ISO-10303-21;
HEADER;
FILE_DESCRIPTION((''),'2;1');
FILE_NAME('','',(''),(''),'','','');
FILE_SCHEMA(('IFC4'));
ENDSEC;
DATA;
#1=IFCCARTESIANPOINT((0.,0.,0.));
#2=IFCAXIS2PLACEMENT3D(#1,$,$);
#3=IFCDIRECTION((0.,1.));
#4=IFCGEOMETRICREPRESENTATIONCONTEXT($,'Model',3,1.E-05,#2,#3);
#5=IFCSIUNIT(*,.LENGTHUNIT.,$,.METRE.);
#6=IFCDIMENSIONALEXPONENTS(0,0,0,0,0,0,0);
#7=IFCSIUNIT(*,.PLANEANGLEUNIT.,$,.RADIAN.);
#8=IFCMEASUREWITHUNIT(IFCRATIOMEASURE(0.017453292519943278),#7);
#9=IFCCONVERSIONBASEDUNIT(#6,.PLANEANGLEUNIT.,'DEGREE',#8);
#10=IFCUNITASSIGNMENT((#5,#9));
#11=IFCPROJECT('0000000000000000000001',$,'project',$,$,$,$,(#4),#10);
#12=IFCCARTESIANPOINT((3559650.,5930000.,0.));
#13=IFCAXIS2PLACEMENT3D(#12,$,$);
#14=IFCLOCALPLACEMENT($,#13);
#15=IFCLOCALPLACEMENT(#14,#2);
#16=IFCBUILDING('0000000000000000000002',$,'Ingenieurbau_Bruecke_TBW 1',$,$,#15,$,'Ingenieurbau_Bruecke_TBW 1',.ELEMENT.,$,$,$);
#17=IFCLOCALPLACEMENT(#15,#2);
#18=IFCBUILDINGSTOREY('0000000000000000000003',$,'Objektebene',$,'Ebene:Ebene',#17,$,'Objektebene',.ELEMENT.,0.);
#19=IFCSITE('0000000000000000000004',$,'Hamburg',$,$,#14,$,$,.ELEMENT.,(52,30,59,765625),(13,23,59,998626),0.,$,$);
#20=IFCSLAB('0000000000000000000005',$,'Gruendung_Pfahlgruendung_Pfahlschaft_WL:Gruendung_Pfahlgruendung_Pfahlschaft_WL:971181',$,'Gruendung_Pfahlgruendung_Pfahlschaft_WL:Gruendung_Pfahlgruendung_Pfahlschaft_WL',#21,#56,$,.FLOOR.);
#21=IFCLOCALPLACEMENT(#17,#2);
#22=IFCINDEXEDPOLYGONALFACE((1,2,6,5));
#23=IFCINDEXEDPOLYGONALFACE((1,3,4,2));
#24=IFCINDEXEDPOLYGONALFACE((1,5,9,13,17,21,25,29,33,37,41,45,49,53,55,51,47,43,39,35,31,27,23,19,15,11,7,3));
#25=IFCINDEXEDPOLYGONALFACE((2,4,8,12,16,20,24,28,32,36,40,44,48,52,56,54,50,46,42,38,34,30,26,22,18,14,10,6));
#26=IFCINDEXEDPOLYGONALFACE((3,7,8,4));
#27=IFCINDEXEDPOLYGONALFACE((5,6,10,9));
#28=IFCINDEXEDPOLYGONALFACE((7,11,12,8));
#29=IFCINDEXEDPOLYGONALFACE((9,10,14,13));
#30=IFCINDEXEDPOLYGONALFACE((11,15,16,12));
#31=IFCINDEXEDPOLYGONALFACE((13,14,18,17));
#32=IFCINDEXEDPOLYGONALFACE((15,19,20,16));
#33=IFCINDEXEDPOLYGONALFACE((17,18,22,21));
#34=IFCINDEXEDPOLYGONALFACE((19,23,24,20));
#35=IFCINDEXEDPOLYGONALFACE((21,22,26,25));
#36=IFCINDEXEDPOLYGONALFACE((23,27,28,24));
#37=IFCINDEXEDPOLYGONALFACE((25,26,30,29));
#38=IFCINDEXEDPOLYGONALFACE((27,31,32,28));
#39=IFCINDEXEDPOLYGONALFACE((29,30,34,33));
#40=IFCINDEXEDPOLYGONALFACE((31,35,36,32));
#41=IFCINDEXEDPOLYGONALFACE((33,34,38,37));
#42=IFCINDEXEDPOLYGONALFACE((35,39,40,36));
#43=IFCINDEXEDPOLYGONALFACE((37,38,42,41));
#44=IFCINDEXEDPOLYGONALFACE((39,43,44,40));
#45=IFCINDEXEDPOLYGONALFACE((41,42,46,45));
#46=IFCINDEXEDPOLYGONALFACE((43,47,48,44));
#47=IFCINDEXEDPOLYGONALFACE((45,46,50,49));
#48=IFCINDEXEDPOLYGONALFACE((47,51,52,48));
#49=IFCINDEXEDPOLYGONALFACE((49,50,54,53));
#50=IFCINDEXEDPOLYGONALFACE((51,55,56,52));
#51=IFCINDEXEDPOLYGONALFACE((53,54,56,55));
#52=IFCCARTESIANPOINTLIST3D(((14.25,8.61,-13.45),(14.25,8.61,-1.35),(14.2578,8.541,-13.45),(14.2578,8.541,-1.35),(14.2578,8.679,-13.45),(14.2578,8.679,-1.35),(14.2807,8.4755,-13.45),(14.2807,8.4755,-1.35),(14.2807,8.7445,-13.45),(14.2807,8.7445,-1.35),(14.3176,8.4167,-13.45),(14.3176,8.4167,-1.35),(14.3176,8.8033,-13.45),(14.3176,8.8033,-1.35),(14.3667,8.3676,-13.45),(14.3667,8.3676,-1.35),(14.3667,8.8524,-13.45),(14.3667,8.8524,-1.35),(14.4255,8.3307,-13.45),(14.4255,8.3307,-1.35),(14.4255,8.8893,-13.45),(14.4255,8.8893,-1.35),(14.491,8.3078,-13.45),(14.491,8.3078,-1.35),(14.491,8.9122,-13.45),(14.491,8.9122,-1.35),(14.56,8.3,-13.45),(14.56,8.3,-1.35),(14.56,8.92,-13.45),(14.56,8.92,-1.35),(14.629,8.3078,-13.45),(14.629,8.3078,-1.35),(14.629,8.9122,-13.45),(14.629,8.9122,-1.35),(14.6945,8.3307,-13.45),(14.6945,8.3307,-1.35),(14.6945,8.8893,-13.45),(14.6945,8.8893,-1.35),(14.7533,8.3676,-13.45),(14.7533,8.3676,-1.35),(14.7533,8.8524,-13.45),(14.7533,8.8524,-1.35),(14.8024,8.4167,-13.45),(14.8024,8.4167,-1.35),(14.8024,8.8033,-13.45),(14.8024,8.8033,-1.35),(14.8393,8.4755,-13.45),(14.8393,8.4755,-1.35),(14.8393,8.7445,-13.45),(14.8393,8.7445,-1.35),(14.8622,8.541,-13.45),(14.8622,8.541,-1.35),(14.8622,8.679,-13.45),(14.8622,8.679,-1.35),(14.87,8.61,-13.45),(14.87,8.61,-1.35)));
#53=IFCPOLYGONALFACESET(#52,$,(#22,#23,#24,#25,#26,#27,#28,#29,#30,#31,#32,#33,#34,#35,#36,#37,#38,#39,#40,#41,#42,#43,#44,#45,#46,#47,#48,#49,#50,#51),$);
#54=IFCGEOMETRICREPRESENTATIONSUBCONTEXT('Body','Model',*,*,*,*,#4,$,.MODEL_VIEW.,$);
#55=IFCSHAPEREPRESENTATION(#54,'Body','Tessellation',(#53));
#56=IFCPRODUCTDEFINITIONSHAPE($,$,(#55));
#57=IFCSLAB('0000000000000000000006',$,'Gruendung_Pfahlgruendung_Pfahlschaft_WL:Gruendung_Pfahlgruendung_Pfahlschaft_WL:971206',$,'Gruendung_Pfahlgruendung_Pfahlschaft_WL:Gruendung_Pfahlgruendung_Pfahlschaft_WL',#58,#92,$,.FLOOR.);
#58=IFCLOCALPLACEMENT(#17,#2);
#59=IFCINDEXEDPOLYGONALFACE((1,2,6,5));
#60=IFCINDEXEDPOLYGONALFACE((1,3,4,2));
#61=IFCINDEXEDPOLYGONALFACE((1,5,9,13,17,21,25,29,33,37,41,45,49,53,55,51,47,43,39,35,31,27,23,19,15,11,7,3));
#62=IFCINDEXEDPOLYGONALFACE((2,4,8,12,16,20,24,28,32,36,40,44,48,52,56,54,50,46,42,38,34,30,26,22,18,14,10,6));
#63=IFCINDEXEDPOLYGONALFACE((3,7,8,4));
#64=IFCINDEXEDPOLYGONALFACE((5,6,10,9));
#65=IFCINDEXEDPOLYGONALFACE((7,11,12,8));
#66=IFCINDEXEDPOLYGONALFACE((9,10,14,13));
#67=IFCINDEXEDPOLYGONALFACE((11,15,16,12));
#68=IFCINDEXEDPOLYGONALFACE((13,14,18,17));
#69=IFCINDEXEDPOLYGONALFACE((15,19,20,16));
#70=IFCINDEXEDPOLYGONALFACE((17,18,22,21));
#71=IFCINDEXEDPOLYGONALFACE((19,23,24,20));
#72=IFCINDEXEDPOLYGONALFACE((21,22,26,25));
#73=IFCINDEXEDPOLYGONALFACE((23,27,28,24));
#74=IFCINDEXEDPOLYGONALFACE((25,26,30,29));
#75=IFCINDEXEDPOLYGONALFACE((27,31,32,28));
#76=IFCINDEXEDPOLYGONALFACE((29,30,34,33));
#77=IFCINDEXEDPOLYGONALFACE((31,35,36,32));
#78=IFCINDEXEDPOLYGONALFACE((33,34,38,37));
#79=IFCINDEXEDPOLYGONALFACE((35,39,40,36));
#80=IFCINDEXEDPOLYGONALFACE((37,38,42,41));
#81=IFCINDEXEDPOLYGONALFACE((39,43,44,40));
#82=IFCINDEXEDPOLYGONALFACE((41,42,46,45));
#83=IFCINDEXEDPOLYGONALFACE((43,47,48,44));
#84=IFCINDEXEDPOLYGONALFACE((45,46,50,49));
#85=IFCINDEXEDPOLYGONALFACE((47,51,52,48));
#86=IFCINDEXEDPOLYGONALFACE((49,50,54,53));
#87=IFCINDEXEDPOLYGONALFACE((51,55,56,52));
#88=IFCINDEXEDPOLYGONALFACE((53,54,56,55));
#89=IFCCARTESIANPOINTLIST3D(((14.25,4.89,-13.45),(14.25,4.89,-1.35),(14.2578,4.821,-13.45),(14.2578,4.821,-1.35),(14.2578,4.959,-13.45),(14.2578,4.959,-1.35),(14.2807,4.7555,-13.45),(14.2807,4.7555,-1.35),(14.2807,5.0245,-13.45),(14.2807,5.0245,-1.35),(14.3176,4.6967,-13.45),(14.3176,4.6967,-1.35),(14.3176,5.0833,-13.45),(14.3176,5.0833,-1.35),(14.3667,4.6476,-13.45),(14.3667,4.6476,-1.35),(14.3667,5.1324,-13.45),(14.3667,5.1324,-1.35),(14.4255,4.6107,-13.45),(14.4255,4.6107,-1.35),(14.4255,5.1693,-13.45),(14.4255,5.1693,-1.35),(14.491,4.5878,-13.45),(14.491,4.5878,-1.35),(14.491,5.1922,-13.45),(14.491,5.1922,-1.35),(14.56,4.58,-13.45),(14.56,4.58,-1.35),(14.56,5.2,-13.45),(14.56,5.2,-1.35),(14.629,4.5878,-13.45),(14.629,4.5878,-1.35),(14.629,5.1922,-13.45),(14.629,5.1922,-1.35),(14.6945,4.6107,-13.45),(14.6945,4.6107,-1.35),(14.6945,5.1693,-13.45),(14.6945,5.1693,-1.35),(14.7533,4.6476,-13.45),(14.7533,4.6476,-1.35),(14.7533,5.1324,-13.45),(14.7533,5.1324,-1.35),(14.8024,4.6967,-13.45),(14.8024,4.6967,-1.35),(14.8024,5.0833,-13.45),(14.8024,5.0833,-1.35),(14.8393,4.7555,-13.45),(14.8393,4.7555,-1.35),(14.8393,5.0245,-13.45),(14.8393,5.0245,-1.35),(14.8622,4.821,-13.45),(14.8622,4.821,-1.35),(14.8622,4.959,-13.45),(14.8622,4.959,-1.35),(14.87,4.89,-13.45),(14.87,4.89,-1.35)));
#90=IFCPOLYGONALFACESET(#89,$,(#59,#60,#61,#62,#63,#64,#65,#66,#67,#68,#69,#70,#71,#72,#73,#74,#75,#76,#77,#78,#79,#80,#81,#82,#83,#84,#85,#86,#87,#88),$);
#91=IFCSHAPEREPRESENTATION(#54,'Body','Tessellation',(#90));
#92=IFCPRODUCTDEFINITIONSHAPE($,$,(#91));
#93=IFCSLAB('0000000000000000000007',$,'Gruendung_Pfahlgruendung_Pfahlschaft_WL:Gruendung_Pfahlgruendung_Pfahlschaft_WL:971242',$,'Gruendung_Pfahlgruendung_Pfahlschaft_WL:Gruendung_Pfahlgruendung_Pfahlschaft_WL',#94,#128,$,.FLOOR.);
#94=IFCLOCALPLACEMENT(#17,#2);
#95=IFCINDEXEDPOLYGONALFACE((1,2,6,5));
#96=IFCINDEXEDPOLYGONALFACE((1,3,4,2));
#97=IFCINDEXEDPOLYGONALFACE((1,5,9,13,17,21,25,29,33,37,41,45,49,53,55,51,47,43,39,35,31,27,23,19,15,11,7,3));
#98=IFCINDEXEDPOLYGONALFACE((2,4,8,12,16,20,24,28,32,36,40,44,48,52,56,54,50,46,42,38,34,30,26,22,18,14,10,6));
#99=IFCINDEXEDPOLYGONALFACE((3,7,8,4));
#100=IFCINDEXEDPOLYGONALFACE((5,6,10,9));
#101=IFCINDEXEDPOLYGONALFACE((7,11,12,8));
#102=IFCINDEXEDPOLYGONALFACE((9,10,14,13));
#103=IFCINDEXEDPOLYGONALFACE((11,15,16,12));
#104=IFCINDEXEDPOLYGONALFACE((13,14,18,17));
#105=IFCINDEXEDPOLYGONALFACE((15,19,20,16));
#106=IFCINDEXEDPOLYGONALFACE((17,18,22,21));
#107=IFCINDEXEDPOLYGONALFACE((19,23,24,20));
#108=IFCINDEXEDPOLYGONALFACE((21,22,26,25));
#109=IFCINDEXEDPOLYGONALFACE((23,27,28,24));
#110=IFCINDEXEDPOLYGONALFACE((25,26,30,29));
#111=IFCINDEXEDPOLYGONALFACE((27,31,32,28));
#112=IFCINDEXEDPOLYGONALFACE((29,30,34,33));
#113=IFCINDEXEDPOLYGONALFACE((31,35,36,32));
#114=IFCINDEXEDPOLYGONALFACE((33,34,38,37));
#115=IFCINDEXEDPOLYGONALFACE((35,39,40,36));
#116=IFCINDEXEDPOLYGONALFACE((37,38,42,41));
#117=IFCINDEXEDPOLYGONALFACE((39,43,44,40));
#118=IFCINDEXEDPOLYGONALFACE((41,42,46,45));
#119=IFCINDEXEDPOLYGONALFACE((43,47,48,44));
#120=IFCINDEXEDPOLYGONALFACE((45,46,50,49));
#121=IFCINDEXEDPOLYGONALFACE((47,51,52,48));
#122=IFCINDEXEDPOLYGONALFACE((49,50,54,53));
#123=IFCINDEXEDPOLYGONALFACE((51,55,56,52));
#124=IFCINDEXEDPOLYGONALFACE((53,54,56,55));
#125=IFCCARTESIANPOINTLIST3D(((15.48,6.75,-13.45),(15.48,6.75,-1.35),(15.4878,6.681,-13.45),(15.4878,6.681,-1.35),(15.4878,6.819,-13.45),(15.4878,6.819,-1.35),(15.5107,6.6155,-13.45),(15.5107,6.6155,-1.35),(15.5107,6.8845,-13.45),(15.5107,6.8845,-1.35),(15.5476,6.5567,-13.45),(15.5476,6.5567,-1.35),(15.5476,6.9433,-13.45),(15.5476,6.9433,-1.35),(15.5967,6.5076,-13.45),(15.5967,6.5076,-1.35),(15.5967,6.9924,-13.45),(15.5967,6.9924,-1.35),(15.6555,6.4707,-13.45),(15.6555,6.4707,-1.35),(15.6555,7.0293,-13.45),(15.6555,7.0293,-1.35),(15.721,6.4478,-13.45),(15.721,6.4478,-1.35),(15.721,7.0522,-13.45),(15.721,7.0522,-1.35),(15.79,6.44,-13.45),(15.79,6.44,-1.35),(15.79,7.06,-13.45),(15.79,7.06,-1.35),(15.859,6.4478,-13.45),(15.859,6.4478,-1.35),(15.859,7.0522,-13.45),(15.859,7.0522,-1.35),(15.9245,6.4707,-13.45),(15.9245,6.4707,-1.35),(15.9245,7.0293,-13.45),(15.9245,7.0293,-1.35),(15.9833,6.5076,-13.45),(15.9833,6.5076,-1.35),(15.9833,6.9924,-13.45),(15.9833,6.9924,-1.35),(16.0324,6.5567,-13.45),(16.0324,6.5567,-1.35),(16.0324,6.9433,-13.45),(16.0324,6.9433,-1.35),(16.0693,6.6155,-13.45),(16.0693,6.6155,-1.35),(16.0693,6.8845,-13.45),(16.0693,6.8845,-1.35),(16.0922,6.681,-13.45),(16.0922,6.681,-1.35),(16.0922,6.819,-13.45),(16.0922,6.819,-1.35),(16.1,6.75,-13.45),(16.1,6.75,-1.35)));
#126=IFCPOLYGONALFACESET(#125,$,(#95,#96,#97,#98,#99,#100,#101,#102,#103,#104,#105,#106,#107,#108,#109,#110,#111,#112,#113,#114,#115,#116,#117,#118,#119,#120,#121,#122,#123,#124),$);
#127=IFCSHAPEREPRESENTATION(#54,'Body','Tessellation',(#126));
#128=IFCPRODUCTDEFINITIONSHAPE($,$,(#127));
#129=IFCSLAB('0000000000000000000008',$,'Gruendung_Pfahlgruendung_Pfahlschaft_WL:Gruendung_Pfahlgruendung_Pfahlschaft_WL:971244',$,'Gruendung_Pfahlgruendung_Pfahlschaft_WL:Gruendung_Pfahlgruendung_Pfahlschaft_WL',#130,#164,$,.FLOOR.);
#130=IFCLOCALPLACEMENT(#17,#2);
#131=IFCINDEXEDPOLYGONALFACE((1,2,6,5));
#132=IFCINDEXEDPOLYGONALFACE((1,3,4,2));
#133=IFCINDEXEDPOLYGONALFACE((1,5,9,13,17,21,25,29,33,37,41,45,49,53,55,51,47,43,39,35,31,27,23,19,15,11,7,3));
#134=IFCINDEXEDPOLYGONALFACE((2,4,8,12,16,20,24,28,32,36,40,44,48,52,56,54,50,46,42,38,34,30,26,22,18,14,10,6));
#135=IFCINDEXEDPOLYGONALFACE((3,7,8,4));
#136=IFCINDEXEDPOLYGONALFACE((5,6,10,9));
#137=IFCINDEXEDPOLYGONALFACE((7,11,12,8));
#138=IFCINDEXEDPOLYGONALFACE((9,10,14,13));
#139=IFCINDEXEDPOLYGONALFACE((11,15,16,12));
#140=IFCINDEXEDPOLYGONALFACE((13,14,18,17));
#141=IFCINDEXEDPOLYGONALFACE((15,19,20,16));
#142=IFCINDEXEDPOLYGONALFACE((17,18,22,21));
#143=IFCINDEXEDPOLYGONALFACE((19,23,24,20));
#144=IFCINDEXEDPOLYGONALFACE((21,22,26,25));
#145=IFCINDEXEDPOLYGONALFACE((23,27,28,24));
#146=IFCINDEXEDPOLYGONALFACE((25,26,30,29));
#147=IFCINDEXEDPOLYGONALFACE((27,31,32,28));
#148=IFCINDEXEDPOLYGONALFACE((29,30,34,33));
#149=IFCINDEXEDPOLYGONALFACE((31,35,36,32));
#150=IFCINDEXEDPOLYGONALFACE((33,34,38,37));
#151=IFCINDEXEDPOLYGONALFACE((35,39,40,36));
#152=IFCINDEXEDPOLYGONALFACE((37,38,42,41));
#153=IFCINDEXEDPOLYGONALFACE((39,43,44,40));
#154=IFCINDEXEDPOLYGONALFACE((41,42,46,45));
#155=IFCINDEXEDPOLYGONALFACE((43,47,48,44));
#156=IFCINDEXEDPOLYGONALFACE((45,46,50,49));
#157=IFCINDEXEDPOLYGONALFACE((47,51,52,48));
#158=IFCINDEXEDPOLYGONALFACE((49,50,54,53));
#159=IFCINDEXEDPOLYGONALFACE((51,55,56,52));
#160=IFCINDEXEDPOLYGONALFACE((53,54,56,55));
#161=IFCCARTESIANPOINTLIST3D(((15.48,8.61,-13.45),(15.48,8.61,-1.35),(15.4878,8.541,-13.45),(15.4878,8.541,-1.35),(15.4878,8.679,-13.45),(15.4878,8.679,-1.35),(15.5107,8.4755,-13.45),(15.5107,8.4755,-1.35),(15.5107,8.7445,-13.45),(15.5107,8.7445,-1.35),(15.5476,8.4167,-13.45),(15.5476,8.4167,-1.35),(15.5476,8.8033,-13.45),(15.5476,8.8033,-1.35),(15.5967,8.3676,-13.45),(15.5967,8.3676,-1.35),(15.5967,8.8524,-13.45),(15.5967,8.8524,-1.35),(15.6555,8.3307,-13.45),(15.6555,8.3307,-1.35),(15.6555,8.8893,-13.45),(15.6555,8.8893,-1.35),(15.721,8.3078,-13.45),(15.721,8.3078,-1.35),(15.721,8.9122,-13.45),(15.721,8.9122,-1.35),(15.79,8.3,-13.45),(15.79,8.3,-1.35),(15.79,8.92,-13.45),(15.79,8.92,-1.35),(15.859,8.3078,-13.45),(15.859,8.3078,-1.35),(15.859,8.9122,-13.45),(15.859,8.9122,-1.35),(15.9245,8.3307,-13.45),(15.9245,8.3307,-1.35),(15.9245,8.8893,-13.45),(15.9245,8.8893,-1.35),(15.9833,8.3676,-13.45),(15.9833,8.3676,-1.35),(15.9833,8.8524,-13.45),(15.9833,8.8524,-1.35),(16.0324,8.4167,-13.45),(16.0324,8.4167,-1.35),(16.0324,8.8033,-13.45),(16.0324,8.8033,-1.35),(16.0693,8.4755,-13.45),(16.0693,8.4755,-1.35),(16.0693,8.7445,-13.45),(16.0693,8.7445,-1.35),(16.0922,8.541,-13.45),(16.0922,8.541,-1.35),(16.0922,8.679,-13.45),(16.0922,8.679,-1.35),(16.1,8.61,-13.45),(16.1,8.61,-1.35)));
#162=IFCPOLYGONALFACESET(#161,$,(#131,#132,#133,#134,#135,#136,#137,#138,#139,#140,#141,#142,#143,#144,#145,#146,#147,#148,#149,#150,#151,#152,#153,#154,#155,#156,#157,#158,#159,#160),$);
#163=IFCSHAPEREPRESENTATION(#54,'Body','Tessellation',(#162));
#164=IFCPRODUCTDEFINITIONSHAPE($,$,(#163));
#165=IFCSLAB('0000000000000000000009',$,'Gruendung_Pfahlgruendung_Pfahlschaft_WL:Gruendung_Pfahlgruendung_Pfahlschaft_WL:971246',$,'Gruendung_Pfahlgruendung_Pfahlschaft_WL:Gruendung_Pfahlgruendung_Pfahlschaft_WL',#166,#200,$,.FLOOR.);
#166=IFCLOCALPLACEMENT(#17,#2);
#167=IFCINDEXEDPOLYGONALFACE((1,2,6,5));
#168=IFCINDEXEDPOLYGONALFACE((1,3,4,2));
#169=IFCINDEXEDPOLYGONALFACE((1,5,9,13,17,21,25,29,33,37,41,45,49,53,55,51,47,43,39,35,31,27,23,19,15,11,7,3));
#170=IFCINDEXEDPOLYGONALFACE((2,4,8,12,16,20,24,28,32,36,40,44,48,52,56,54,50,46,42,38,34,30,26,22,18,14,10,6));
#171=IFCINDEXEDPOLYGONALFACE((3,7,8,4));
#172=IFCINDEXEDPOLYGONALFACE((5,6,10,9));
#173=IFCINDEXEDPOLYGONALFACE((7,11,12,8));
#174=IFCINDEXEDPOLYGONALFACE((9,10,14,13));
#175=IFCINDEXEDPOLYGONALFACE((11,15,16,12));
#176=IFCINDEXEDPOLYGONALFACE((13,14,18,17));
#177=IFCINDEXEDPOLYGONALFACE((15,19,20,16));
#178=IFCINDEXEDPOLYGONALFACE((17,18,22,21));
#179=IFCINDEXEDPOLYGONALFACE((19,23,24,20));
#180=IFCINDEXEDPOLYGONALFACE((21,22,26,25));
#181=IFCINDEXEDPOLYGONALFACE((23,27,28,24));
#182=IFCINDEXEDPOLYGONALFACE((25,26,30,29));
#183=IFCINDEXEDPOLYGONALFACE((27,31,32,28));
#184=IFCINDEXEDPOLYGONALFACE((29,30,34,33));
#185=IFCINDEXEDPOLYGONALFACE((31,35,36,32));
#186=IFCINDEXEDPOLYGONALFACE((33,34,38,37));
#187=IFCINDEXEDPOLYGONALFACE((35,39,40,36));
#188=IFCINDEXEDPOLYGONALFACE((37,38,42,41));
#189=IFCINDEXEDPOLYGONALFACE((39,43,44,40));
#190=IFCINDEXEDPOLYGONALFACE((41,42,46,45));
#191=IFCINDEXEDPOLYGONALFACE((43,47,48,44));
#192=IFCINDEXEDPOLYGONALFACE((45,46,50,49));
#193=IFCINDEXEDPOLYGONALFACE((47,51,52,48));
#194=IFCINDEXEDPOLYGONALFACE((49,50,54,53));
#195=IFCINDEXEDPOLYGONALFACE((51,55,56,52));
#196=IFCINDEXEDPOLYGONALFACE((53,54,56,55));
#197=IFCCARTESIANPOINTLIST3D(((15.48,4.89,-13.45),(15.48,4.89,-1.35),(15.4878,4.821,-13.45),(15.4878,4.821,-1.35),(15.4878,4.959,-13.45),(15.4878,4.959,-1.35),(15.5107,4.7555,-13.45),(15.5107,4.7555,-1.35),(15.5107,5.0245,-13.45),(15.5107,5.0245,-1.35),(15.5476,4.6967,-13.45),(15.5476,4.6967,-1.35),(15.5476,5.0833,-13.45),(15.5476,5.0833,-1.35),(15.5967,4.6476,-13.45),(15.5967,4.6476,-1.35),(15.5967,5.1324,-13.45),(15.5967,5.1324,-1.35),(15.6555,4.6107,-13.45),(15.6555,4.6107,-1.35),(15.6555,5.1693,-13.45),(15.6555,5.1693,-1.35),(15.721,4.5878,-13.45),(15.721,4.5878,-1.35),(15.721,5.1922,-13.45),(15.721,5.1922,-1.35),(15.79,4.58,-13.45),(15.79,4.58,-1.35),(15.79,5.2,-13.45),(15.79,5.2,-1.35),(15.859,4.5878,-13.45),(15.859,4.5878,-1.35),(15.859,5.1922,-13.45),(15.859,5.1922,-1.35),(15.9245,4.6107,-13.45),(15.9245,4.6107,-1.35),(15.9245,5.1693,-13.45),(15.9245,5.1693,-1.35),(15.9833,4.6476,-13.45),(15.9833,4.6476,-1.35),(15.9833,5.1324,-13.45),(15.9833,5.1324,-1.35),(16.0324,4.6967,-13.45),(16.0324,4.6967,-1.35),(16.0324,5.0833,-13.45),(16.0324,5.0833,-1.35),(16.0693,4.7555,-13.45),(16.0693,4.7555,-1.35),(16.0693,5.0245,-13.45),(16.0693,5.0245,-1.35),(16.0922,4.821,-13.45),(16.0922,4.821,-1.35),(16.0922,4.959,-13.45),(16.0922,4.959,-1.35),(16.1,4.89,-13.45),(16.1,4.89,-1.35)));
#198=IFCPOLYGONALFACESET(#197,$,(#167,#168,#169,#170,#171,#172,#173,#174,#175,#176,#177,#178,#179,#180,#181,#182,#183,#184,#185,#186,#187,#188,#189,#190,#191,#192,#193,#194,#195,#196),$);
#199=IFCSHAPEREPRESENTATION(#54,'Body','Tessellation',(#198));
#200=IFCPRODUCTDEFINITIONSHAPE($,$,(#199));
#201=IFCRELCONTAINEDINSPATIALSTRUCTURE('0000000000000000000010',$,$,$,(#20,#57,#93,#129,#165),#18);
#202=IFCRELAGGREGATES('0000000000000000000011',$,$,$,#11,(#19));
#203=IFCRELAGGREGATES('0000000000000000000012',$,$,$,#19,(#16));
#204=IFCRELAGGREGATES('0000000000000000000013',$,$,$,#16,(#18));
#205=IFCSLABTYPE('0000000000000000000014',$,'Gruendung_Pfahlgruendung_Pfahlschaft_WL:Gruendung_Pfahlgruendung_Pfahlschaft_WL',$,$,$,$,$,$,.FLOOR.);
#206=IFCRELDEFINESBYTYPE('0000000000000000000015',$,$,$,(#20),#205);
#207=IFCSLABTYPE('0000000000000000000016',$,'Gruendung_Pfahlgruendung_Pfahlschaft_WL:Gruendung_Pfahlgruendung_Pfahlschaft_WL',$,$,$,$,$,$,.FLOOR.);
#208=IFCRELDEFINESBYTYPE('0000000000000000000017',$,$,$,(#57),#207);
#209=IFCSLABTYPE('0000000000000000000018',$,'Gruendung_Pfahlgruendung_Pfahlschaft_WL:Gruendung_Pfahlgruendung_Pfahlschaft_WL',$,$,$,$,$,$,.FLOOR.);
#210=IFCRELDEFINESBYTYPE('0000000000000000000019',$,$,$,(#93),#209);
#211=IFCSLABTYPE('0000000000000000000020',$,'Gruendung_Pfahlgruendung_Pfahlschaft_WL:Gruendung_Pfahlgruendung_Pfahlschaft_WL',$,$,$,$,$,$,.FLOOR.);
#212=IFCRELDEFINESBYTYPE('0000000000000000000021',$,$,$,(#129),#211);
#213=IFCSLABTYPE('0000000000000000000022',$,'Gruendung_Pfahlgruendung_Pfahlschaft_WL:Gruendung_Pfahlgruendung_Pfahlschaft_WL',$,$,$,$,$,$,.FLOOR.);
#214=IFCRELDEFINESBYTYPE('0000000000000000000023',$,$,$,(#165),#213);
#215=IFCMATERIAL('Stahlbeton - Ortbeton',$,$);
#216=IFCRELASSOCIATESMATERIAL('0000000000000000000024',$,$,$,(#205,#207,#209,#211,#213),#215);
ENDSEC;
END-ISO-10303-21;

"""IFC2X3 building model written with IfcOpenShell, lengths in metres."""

from ifc_helpers import new_model, entity, si_unit, converted_unit, direction, frame, frame_2d, origin, origin_2d_with_axis, place, context, subcontext, project, spatial, circle, extrude, material, type_object, element, save


model = new_model("IFC2X3")

# Units and contexts
model_context = context("Model", 3, precision=1e-05, world=origin(), true_north=direction((0.0, 1.0)))
body_context = subcontext(model_context, "Body", "Model", "MODEL_VIEW")
ifc_project = project(units=[si_unit("LENGTHUNIT", "METRE"), converted_unit("PLANEANGLEUNIT", "DEGREE", entity("IfcRatioMeasure", 0.017453292519943278), si_unit("PLANEANGLEUNIT", "RADIAN"), dimensions=[0, 0, 0, 0, 0, 0, 0])], contexts=[model_context])

# Site, building, storey
site_placement = place(None, frame((3559650.0, 5930000.0, 0.0)))
site = spatial("IfcSite", under=ifc_project, at=site_placement, Name="Hamburg", CompositionType="ELEMENT", RefLatitude=(52, 30, 59, 765625), RefLongitude=(13, 23, 59, 998626), RefElevation=0.0)
building_placement = place(site_placement, origin())
building = spatial("IfcBuilding", under=site, at=building_placement, Name="Ingenieurbau_Bruecke_TBW 1", LongName="Ingenieurbau_Bruecke_TBW 1", CompositionType="ELEMENT")
storey_placement = place(building_placement, origin())
storey = spatial("IfcBuildingStorey", under=building, at=storey_placement, Name="Objektebene", ObjectType="Ebene:Ebene", LongName="Objektebene", CompositionType="ELEMENT", Elevation=0.0)

# Slabs
ifc_material_1 = material(Name="Stahlbeton - Ortbeton")
slab_type_1 = type_object("IfcSlabType", Name="Gruendung_Pfahlgruendung_Pfahlschaft_WL:Gruendung_Pfahlgruendung_Pfahlschaft_WL", PredefinedType="FLOOR", material=ifc_material_1)
slab_1_placement = place(storey_placement, origin())
element("IfcSlab", 1, at=slab_1_placement, inside=storey, type_object=slab_type_1, Name="Gruendung_Pfahlgruendung_Pfahlschaft_WL:Gruendung_Pfahlgruendung_Pfahlschaft_WL:971181", ObjectType="Gruendung_Pfahlgruendung_Pfahlschaft_WL:Gruendung_Pfahlgruendung_Pfahlschaft_WL", PredefinedType="FLOOR", context=body_context, shape_type="SweptSolid", body=[
    extrude(circle(Radius=0.31, at=frame_2d((0.0, 0.0), x_axis=(1.0, 0.0))), frame((14.56, 8.61, -13.45)), (0.0, 0.0, 1.0), 12.1),
])
slab_type_2 = type_object("IfcSlabType", Name="Gruendung_Pfahlgruendung_Pfahlschaft_WL:Gruendung_Pfahlgruendung_Pfahlschaft_WL", PredefinedType="FLOOR", material=ifc_material_1)
slab_2_placement = place(storey_placement, origin())
element("IfcSlab", 2, at=slab_2_placement, inside=storey, type_object=slab_type_2, Name="Gruendung_Pfahlgruendung_Pfahlschaft_WL:Gruendung_Pfahlgruendung_Pfahlschaft_WL:971206", ObjectType="Gruendung_Pfahlgruendung_Pfahlschaft_WL:Gruendung_Pfahlgruendung_Pfahlschaft_WL", PredefinedType="FLOOR", context=body_context, shape_type="SweptSolid", body=[
    extrude(circle(Radius=0.31, at=origin_2d_with_axis()), frame((14.56, 4.89, -13.45)), (0.0, 0.0, 1.0), 12.1),
])
slab_type_3 = type_object("IfcSlabType", Name="Gruendung_Pfahlgruendung_Pfahlschaft_WL:Gruendung_Pfahlgruendung_Pfahlschaft_WL", PredefinedType="FLOOR", material=ifc_material_1)
slab_3_placement = place(storey_placement, origin())
element("IfcSlab", 3, at=slab_3_placement, inside=storey, type_object=slab_type_3, Name="Gruendung_Pfahlgruendung_Pfahlschaft_WL:Gruendung_Pfahlgruendung_Pfahlschaft_WL:971242", ObjectType="Gruendung_Pfahlgruendung_Pfahlschaft_WL:Gruendung_Pfahlgruendung_Pfahlschaft_WL", PredefinedType="FLOOR", context=body_context, shape_type="SweptSolid", body=[
    extrude(circle(Radius=0.31, at=frame_2d((0.0, 0.0), x_axis=(1.0, 0.0))), frame((15.79, 6.75, -13.45)), (0.0, 0.0, 1.0), 12.1),
])
slab_type_4 = type_object("IfcSlabType", Name="Gruendung_Pfahlgruendung_Pfahlschaft_WL:Gruendung_Pfahlgruendung_Pfahlschaft_WL", PredefinedType="FLOOR", material=ifc_material_1)
slab_4_placement = place(storey_placement, origin())
element("IfcSlab", 4, at=slab_4_placement, inside=storey, type_object=slab_type_4, Name="Gruendung_Pfahlgruendung_Pfahlschaft_WL:Gruendung_Pfahlgruendung_Pfahlschaft_WL:971244", ObjectType="Gruendung_Pfahlgruendung_Pfahlschaft_WL:Gruendung_Pfahlgruendung_Pfahlschaft_WL", PredefinedType="FLOOR", context=body_context, shape_type="SweptSolid", body=[
    extrude(circle(Radius=0.31, at=frame_2d((0.0, 0.0), x_axis=(1.0, 0.0))), frame((15.79, 8.61, -13.45)), (0.0, 0.0, 1.0), 12.1),
])
slab_type_5 = type_object("IfcSlabType", Name="Gruendung_Pfahlgruendung_Pfahlschaft_WL:Gruendung_Pfahlgruendung_Pfahlschaft_WL", PredefinedType="FLOOR", material=ifc_material_1)
slab_5_placement = place(storey_placement, origin())
element("IfcSlab", 5, at=slab_5_placement, inside=storey, type_object=slab_type_5, Name="Gruendung_Pfahlgruendung_Pfahlschaft_WL:Gruendung_Pfahlgruendung_Pfahlschaft_WL:971246", ObjectType="Gruendung_Pfahlgruendung_Pfahlschaft_WL:Gruendung_Pfahlgruendung_Pfahlschaft_WL", PredefinedType="FLOOR", context=body_context, shape_type="SweptSolid", body=[
    extrude(circle(Radius=0.31, at=origin_2d_with_axis()), frame((15.79, 4.89, -13.45)), (0.0, 0.0, 1.0), 12.1),
])

save(model, "model.ifc")
